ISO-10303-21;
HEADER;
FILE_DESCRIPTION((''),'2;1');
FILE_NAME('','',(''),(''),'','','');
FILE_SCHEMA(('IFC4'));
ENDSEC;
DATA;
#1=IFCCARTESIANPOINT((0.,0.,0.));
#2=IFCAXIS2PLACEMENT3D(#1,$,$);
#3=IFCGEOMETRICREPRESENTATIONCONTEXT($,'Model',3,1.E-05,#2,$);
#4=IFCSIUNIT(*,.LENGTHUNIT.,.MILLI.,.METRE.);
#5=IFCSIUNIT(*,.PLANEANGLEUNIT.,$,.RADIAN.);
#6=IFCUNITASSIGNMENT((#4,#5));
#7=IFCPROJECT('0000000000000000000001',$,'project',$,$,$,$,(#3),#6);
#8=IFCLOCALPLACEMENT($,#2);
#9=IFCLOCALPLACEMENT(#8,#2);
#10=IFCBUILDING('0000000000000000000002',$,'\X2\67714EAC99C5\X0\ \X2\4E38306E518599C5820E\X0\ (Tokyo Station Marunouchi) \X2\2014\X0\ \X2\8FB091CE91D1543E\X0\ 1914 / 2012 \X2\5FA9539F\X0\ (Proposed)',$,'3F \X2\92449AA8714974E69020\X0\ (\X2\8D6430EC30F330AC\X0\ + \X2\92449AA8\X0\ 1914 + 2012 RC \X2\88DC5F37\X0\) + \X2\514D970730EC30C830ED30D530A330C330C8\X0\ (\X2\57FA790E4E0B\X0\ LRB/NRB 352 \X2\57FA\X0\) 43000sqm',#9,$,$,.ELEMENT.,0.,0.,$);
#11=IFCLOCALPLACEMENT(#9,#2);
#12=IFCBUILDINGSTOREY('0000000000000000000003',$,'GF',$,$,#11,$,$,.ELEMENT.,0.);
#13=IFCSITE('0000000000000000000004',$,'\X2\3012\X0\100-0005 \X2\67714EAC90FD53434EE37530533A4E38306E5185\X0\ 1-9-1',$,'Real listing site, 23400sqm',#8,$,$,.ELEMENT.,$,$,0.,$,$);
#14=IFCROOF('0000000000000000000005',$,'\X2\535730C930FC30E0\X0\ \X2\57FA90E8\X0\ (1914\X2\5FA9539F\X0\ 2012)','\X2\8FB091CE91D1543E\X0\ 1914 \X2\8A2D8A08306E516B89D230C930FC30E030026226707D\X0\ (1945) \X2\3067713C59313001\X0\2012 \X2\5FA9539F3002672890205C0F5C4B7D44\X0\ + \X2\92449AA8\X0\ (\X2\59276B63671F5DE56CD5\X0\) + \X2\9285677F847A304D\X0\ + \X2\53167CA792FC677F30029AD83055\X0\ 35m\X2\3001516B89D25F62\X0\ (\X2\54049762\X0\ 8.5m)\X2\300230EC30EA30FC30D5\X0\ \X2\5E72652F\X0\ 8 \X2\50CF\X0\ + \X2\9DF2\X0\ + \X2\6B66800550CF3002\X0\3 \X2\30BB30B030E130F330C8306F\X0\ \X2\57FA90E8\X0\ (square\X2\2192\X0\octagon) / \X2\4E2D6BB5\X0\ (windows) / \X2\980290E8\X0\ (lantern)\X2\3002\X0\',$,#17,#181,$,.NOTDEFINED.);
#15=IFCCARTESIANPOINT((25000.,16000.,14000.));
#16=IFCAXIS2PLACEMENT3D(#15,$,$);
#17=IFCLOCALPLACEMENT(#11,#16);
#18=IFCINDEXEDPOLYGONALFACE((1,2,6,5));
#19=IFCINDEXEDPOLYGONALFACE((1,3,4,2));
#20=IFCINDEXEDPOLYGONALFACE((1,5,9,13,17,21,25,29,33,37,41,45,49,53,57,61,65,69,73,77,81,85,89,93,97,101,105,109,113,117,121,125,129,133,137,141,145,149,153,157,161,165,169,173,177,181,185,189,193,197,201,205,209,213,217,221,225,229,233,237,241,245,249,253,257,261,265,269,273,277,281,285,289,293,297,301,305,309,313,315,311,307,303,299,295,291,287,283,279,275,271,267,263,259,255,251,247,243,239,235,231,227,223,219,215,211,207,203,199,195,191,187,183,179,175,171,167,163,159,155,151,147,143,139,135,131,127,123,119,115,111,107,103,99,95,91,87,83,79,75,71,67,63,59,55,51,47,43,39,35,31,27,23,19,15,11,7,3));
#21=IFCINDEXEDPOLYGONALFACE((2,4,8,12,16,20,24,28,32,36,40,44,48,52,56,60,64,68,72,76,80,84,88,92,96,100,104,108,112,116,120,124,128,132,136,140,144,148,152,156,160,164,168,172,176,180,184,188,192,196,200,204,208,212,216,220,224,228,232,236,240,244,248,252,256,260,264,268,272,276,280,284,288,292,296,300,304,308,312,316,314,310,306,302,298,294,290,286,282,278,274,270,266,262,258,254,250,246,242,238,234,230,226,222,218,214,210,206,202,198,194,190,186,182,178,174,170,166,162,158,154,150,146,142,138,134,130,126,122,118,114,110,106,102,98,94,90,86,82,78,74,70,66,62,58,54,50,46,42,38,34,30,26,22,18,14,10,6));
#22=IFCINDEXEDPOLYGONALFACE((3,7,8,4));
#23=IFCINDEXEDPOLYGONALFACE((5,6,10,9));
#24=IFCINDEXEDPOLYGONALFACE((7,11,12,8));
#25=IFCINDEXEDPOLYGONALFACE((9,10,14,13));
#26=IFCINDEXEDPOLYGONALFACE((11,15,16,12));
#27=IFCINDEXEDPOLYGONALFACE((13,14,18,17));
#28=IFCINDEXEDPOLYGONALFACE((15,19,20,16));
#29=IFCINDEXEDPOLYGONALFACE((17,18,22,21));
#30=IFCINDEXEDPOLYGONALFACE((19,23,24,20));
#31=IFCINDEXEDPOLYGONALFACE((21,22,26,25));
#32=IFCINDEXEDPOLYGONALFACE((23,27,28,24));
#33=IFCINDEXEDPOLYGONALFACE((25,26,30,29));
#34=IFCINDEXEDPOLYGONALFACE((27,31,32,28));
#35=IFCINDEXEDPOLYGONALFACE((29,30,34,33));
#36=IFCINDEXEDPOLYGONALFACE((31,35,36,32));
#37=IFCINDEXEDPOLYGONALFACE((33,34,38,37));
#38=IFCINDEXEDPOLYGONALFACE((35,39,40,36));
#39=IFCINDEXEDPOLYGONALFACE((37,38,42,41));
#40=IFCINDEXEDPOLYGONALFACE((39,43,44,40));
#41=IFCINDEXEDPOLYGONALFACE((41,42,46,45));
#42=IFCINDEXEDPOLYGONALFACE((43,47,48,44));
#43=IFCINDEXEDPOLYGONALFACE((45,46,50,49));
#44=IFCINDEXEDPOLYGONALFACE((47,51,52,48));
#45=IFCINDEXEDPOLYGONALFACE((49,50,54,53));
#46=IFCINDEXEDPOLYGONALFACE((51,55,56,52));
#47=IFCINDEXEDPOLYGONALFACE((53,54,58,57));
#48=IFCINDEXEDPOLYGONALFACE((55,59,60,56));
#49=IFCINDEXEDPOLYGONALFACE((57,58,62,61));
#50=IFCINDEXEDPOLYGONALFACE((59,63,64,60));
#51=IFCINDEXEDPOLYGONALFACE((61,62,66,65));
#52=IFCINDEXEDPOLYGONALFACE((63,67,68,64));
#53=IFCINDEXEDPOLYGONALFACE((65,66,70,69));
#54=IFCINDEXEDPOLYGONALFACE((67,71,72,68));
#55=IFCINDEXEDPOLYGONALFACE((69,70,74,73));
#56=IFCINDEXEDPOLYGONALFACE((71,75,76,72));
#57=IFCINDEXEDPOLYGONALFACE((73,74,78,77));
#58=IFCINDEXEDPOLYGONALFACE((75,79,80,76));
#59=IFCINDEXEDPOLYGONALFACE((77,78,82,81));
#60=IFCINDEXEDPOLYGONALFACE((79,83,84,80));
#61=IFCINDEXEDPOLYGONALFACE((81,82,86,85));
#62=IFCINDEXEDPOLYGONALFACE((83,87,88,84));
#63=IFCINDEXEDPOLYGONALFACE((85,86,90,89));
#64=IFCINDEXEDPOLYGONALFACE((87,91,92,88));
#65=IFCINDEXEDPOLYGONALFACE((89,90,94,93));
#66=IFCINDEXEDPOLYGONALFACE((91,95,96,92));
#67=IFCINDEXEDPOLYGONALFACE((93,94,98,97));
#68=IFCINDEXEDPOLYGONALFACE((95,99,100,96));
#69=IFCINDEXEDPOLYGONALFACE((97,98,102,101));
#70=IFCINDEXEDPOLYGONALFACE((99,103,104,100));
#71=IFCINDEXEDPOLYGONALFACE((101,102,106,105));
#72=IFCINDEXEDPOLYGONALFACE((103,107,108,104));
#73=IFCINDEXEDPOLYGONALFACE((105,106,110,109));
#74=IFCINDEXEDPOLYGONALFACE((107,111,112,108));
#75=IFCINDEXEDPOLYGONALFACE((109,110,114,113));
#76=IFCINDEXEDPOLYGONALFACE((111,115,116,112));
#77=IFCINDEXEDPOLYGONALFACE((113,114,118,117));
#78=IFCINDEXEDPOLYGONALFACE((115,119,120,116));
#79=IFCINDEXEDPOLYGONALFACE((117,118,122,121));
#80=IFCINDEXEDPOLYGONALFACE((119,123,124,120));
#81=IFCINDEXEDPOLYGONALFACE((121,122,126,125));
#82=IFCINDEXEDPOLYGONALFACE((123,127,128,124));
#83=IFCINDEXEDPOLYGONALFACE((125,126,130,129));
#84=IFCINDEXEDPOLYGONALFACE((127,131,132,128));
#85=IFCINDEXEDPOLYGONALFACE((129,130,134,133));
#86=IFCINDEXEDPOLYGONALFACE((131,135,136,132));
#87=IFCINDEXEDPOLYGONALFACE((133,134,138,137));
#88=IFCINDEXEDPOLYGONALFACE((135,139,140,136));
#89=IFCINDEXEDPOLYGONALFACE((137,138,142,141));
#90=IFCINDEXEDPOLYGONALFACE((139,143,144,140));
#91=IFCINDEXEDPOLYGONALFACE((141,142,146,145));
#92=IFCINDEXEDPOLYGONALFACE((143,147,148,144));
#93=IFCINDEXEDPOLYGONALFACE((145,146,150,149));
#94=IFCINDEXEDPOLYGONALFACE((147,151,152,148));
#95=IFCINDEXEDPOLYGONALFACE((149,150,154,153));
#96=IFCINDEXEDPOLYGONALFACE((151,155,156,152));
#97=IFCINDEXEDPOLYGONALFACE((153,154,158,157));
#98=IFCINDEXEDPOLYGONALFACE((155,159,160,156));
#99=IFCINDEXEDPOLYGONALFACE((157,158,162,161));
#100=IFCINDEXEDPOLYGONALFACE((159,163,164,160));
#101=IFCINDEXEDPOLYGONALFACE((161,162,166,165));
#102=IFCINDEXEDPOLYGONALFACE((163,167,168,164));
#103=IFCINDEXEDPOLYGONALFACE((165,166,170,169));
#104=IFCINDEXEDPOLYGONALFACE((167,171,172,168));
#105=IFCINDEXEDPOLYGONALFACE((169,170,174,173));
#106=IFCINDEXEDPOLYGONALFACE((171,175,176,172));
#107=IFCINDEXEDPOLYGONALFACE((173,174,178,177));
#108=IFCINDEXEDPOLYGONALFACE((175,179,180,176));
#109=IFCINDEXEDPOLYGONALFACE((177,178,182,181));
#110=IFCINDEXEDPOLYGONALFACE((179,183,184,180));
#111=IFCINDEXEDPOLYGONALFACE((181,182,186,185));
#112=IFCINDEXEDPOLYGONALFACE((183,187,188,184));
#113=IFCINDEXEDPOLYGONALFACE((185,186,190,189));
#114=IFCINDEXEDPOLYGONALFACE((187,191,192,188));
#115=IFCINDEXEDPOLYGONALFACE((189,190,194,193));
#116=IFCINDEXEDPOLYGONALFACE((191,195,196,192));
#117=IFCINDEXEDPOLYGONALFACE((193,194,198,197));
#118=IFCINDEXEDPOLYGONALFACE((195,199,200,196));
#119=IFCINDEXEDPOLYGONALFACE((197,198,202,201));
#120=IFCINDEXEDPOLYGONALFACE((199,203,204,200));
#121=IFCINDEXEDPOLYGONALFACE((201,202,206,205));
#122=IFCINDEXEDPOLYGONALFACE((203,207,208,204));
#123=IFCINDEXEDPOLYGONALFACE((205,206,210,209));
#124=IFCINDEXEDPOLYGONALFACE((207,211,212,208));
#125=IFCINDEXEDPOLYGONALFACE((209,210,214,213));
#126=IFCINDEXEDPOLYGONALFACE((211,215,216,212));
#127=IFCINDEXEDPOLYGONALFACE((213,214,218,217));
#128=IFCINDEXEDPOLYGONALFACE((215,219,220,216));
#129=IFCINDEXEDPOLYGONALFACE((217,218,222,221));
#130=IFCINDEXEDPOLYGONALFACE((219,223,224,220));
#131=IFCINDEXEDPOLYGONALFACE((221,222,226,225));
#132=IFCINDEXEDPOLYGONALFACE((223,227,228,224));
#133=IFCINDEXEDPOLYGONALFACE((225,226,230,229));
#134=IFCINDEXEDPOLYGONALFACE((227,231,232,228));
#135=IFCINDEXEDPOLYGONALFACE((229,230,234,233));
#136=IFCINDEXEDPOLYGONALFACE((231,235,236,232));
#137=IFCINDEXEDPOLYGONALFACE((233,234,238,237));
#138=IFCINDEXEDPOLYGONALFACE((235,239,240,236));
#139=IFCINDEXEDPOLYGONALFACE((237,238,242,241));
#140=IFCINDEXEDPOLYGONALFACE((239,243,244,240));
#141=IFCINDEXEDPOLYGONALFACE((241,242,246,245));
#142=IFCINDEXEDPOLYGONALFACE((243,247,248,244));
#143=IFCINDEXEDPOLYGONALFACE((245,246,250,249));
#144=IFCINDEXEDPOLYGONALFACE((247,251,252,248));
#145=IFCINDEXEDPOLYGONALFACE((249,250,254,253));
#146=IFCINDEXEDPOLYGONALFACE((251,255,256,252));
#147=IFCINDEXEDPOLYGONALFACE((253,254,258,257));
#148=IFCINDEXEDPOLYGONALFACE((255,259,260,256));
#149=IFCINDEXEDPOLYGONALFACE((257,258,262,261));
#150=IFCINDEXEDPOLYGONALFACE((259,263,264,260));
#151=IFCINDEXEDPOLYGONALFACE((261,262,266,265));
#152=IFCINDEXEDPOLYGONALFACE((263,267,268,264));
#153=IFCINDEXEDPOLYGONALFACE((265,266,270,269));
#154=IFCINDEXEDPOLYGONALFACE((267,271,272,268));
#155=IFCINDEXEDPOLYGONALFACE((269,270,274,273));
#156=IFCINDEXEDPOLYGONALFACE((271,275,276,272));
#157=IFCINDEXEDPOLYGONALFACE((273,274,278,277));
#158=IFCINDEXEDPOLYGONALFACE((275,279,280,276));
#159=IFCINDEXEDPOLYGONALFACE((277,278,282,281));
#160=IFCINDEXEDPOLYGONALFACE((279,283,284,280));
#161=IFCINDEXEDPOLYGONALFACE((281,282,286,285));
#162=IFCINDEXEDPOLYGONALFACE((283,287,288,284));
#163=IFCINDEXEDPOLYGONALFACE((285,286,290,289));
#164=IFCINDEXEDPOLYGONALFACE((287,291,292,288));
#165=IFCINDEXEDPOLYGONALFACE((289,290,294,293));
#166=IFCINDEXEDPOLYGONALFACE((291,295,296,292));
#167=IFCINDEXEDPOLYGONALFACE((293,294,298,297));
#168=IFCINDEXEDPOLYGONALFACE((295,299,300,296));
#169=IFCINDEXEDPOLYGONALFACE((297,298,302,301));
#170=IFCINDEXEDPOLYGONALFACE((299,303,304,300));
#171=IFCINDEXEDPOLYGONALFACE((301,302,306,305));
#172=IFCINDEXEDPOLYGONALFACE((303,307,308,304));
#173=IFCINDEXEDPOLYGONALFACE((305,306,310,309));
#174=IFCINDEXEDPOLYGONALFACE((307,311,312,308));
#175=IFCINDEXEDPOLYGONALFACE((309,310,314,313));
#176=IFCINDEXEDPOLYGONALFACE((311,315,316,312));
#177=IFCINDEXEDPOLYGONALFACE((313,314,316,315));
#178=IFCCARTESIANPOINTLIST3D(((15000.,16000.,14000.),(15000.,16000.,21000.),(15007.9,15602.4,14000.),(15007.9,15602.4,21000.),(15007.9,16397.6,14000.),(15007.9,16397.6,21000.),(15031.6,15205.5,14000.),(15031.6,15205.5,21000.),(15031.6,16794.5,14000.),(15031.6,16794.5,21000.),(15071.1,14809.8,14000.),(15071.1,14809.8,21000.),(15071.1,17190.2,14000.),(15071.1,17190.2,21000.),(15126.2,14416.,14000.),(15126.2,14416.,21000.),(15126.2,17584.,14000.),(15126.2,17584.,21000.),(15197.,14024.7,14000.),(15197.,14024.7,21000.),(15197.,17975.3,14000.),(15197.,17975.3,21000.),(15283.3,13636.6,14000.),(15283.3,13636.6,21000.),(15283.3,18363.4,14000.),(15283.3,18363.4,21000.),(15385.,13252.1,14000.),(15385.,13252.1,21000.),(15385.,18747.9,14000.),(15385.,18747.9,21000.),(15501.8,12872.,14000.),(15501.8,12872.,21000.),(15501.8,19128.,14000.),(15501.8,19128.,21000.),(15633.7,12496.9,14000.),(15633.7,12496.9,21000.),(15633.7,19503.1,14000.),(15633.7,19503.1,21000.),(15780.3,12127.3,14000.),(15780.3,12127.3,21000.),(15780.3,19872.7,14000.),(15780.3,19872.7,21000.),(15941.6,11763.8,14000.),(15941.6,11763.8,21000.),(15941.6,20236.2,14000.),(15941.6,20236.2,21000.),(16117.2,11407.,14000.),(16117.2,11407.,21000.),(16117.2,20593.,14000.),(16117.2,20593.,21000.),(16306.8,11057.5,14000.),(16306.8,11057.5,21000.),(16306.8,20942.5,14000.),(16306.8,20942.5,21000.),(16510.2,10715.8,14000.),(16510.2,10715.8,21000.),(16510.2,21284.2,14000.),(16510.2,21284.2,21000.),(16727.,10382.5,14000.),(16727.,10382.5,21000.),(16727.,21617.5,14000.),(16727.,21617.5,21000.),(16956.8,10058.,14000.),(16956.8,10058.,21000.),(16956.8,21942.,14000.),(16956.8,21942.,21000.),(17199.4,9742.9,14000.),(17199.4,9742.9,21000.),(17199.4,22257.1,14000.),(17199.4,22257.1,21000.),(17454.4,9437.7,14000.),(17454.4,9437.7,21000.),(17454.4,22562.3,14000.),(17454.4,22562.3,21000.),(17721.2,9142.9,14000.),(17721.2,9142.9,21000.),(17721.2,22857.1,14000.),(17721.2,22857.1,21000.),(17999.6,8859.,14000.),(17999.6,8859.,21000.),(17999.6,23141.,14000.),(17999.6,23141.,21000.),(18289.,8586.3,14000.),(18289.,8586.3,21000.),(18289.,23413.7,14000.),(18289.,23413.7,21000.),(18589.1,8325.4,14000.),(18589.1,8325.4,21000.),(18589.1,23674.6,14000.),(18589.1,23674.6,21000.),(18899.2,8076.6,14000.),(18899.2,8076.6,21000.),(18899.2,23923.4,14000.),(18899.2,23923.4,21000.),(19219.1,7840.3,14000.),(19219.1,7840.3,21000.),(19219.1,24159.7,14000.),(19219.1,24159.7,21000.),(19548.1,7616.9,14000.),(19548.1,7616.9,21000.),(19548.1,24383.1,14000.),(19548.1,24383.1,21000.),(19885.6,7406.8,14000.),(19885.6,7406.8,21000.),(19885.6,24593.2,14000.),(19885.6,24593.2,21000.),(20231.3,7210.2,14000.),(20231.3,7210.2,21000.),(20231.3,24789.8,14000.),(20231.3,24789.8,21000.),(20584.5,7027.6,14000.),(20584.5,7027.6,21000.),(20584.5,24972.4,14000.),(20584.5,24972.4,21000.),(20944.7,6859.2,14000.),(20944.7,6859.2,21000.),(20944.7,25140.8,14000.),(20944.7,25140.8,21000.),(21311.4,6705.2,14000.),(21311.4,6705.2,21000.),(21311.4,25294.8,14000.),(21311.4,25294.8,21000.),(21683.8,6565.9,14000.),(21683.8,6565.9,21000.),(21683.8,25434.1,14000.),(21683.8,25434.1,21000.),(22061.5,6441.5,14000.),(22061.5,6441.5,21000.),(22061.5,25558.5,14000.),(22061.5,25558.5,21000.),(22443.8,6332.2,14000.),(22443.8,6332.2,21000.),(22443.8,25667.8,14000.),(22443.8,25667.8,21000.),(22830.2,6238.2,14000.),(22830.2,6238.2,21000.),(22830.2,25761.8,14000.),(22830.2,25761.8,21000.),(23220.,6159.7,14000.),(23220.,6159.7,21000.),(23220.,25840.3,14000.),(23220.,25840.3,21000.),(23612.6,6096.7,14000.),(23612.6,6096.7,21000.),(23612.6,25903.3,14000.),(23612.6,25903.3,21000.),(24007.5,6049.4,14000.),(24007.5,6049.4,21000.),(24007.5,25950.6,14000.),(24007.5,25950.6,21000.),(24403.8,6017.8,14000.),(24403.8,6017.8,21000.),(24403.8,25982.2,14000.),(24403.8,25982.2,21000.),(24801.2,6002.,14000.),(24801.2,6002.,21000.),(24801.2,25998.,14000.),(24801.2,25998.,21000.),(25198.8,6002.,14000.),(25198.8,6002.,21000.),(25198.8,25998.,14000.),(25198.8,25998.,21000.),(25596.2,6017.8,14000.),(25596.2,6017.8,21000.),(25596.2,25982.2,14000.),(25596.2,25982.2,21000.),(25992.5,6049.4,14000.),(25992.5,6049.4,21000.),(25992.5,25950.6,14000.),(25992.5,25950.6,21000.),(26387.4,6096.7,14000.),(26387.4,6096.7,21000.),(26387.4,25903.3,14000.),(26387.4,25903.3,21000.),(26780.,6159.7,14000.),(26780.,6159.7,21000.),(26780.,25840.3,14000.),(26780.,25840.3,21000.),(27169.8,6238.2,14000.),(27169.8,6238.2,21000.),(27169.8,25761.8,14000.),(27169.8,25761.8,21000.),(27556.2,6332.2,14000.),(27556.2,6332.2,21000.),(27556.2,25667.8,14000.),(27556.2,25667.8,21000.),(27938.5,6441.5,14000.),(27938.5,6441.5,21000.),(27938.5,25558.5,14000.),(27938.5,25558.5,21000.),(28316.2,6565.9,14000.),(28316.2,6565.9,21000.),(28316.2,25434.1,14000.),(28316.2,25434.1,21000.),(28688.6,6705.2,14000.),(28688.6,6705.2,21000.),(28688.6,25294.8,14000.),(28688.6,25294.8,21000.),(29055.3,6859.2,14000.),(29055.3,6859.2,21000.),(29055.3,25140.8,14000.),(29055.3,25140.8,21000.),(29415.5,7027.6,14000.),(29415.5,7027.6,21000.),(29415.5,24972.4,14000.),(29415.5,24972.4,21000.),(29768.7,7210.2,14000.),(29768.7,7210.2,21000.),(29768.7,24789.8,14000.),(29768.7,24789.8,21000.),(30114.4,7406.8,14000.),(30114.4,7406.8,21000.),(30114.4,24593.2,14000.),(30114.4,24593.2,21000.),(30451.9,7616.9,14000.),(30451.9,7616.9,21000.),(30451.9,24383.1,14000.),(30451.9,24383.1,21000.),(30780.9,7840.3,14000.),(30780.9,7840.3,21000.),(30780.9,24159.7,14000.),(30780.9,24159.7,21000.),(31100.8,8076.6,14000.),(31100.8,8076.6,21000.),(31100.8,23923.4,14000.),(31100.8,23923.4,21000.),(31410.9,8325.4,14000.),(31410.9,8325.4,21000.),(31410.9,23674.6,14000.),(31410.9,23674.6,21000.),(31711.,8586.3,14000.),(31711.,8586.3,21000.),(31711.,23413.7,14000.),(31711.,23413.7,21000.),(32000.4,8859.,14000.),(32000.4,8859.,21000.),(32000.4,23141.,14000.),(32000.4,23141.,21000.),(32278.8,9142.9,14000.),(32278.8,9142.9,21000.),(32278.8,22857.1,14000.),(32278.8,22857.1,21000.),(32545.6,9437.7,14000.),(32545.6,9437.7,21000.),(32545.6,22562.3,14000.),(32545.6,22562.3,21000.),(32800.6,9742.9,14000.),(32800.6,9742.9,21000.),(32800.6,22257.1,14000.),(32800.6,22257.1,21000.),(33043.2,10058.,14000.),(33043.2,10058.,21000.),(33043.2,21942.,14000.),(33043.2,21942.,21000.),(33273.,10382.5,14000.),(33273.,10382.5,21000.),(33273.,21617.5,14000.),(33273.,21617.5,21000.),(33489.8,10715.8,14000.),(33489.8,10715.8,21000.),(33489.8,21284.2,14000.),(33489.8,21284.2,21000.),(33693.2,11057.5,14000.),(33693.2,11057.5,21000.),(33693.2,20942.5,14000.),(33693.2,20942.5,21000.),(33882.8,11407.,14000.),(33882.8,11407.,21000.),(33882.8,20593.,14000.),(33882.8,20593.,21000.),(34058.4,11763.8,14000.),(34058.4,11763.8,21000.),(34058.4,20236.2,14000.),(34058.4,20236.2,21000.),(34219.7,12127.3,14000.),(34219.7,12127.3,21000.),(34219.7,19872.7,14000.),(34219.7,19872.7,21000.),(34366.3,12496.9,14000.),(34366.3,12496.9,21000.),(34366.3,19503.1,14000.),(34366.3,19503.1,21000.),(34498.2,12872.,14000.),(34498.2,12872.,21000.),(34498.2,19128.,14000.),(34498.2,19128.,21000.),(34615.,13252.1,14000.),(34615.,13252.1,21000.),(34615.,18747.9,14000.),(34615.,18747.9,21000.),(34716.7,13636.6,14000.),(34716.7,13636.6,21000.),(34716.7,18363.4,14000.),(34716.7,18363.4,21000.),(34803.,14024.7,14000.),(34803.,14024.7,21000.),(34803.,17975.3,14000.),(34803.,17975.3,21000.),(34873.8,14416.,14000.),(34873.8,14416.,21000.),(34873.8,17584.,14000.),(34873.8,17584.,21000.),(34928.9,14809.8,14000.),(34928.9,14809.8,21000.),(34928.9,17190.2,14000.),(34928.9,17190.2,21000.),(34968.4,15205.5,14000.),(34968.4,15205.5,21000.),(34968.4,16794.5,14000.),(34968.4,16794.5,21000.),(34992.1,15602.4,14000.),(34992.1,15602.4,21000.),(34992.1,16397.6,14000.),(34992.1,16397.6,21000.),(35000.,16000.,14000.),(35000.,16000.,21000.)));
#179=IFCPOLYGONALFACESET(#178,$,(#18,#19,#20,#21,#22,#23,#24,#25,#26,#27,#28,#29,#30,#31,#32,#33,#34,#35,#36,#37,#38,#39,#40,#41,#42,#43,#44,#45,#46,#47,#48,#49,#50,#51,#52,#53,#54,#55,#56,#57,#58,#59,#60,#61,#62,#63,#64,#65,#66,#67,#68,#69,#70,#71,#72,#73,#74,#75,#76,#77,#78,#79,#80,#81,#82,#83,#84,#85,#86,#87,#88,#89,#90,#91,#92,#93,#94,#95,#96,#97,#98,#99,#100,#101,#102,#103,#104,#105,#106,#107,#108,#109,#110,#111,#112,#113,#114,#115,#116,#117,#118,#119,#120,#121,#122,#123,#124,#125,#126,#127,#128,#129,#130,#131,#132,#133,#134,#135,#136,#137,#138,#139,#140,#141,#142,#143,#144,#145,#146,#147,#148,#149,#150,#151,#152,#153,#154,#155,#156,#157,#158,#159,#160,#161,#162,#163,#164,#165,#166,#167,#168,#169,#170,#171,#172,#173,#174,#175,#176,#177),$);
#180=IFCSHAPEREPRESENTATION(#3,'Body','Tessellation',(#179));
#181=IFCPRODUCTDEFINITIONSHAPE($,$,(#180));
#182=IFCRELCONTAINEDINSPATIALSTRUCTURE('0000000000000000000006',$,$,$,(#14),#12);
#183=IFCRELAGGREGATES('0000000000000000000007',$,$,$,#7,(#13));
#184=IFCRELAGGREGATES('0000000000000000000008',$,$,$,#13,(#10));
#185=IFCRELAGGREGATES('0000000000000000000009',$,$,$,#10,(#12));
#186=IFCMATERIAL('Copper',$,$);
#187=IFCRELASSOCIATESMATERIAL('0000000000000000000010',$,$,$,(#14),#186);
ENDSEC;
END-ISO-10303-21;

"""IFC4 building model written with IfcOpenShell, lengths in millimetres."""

from ifc_helpers import new_model, si_unit, frame, origin, origin_2d, place, context, project, spatial, circle, extrude, material, element, save


model = new_model("IFC4")

# Units and contexts
model_context = context("Model", 3, precision=1e-05, world=origin())
ifc_project = project(units=[si_unit("LENGTHUNIT", "METRE", prefix="MILLI"), si_unit("PLANEANGLEUNIT", "RADIAN")], contexts=[model_context])

# Site, building, storey
site_placement = place(None, origin())
site = spatial("IfcSite", under=ifc_project, at=site_placement, Name="〒100-0005 東京都千代田区丸の内 1-9-1", ObjectType="Real listing site, 23400sqm", CompositionType="ELEMENT", RefElevation=0.0)
building_placement = place(site_placement, origin())
building = spatial("IfcBuilding", under=site, at=building_placement, Name="東京駅 丸の内駅舎 (Tokyo Station Marunouchi) — 辰野金吾 1914 / 2012 復原 (Proposed)", ObjectType="3F 鉄骨煉瓦造 (赤レンガ + 鉄骨 1914 + 2012 RC 補強) + 免震レトロフィット (基礎下 LRB/NRB 352 基) 43000sqm", CompositionType="ELEMENT", ElevationOfRefHeight=0.0, ElevationOfTerrain=0.0)
storey_placement = place(building_placement, origin())
storey = spatial("IfcBuildingStorey", under=building, at=storey_placement, Name="GF", CompositionType="ELEMENT", Elevation=0.0)

# Roof
ifc_material_1 = material(Name="Copper")
roof_1_placement = place(storey_placement, frame((25000.0, 16000.0, 14000.0)))
element("IfcRoof", 1, at=roof_1_placement, inside=storey, material=ifc_material_1, Name="南ドーム 基部 (1914復原 2012)", Description="辰野金吾 1914 設計の八角ドーム。戦災 (1945) で焼失、2012 復原。木造小屋組 + 鉄骨 (大正期工法) + 銅板葺き + 化粧鋼板。高さ 35m、八角形 (各面 8.5m)。レリーフ 干支 8 像 + 鷲 + 武者像。3 セグメントは 基部 (square→octagon) / 中段 (windows) / 頂部 (lantern)。", PredefinedType="NOTDEFINED", context=model_context, shape_type="SweptSolid", body=[
    extrude(circle(Radius=10000.0, at=origin_2d()), frame((25000.0, 16000.0, 14000.0)), (0.0, 0.0, 1.0), 7000.0),
])

save(model, "model.ifc")
